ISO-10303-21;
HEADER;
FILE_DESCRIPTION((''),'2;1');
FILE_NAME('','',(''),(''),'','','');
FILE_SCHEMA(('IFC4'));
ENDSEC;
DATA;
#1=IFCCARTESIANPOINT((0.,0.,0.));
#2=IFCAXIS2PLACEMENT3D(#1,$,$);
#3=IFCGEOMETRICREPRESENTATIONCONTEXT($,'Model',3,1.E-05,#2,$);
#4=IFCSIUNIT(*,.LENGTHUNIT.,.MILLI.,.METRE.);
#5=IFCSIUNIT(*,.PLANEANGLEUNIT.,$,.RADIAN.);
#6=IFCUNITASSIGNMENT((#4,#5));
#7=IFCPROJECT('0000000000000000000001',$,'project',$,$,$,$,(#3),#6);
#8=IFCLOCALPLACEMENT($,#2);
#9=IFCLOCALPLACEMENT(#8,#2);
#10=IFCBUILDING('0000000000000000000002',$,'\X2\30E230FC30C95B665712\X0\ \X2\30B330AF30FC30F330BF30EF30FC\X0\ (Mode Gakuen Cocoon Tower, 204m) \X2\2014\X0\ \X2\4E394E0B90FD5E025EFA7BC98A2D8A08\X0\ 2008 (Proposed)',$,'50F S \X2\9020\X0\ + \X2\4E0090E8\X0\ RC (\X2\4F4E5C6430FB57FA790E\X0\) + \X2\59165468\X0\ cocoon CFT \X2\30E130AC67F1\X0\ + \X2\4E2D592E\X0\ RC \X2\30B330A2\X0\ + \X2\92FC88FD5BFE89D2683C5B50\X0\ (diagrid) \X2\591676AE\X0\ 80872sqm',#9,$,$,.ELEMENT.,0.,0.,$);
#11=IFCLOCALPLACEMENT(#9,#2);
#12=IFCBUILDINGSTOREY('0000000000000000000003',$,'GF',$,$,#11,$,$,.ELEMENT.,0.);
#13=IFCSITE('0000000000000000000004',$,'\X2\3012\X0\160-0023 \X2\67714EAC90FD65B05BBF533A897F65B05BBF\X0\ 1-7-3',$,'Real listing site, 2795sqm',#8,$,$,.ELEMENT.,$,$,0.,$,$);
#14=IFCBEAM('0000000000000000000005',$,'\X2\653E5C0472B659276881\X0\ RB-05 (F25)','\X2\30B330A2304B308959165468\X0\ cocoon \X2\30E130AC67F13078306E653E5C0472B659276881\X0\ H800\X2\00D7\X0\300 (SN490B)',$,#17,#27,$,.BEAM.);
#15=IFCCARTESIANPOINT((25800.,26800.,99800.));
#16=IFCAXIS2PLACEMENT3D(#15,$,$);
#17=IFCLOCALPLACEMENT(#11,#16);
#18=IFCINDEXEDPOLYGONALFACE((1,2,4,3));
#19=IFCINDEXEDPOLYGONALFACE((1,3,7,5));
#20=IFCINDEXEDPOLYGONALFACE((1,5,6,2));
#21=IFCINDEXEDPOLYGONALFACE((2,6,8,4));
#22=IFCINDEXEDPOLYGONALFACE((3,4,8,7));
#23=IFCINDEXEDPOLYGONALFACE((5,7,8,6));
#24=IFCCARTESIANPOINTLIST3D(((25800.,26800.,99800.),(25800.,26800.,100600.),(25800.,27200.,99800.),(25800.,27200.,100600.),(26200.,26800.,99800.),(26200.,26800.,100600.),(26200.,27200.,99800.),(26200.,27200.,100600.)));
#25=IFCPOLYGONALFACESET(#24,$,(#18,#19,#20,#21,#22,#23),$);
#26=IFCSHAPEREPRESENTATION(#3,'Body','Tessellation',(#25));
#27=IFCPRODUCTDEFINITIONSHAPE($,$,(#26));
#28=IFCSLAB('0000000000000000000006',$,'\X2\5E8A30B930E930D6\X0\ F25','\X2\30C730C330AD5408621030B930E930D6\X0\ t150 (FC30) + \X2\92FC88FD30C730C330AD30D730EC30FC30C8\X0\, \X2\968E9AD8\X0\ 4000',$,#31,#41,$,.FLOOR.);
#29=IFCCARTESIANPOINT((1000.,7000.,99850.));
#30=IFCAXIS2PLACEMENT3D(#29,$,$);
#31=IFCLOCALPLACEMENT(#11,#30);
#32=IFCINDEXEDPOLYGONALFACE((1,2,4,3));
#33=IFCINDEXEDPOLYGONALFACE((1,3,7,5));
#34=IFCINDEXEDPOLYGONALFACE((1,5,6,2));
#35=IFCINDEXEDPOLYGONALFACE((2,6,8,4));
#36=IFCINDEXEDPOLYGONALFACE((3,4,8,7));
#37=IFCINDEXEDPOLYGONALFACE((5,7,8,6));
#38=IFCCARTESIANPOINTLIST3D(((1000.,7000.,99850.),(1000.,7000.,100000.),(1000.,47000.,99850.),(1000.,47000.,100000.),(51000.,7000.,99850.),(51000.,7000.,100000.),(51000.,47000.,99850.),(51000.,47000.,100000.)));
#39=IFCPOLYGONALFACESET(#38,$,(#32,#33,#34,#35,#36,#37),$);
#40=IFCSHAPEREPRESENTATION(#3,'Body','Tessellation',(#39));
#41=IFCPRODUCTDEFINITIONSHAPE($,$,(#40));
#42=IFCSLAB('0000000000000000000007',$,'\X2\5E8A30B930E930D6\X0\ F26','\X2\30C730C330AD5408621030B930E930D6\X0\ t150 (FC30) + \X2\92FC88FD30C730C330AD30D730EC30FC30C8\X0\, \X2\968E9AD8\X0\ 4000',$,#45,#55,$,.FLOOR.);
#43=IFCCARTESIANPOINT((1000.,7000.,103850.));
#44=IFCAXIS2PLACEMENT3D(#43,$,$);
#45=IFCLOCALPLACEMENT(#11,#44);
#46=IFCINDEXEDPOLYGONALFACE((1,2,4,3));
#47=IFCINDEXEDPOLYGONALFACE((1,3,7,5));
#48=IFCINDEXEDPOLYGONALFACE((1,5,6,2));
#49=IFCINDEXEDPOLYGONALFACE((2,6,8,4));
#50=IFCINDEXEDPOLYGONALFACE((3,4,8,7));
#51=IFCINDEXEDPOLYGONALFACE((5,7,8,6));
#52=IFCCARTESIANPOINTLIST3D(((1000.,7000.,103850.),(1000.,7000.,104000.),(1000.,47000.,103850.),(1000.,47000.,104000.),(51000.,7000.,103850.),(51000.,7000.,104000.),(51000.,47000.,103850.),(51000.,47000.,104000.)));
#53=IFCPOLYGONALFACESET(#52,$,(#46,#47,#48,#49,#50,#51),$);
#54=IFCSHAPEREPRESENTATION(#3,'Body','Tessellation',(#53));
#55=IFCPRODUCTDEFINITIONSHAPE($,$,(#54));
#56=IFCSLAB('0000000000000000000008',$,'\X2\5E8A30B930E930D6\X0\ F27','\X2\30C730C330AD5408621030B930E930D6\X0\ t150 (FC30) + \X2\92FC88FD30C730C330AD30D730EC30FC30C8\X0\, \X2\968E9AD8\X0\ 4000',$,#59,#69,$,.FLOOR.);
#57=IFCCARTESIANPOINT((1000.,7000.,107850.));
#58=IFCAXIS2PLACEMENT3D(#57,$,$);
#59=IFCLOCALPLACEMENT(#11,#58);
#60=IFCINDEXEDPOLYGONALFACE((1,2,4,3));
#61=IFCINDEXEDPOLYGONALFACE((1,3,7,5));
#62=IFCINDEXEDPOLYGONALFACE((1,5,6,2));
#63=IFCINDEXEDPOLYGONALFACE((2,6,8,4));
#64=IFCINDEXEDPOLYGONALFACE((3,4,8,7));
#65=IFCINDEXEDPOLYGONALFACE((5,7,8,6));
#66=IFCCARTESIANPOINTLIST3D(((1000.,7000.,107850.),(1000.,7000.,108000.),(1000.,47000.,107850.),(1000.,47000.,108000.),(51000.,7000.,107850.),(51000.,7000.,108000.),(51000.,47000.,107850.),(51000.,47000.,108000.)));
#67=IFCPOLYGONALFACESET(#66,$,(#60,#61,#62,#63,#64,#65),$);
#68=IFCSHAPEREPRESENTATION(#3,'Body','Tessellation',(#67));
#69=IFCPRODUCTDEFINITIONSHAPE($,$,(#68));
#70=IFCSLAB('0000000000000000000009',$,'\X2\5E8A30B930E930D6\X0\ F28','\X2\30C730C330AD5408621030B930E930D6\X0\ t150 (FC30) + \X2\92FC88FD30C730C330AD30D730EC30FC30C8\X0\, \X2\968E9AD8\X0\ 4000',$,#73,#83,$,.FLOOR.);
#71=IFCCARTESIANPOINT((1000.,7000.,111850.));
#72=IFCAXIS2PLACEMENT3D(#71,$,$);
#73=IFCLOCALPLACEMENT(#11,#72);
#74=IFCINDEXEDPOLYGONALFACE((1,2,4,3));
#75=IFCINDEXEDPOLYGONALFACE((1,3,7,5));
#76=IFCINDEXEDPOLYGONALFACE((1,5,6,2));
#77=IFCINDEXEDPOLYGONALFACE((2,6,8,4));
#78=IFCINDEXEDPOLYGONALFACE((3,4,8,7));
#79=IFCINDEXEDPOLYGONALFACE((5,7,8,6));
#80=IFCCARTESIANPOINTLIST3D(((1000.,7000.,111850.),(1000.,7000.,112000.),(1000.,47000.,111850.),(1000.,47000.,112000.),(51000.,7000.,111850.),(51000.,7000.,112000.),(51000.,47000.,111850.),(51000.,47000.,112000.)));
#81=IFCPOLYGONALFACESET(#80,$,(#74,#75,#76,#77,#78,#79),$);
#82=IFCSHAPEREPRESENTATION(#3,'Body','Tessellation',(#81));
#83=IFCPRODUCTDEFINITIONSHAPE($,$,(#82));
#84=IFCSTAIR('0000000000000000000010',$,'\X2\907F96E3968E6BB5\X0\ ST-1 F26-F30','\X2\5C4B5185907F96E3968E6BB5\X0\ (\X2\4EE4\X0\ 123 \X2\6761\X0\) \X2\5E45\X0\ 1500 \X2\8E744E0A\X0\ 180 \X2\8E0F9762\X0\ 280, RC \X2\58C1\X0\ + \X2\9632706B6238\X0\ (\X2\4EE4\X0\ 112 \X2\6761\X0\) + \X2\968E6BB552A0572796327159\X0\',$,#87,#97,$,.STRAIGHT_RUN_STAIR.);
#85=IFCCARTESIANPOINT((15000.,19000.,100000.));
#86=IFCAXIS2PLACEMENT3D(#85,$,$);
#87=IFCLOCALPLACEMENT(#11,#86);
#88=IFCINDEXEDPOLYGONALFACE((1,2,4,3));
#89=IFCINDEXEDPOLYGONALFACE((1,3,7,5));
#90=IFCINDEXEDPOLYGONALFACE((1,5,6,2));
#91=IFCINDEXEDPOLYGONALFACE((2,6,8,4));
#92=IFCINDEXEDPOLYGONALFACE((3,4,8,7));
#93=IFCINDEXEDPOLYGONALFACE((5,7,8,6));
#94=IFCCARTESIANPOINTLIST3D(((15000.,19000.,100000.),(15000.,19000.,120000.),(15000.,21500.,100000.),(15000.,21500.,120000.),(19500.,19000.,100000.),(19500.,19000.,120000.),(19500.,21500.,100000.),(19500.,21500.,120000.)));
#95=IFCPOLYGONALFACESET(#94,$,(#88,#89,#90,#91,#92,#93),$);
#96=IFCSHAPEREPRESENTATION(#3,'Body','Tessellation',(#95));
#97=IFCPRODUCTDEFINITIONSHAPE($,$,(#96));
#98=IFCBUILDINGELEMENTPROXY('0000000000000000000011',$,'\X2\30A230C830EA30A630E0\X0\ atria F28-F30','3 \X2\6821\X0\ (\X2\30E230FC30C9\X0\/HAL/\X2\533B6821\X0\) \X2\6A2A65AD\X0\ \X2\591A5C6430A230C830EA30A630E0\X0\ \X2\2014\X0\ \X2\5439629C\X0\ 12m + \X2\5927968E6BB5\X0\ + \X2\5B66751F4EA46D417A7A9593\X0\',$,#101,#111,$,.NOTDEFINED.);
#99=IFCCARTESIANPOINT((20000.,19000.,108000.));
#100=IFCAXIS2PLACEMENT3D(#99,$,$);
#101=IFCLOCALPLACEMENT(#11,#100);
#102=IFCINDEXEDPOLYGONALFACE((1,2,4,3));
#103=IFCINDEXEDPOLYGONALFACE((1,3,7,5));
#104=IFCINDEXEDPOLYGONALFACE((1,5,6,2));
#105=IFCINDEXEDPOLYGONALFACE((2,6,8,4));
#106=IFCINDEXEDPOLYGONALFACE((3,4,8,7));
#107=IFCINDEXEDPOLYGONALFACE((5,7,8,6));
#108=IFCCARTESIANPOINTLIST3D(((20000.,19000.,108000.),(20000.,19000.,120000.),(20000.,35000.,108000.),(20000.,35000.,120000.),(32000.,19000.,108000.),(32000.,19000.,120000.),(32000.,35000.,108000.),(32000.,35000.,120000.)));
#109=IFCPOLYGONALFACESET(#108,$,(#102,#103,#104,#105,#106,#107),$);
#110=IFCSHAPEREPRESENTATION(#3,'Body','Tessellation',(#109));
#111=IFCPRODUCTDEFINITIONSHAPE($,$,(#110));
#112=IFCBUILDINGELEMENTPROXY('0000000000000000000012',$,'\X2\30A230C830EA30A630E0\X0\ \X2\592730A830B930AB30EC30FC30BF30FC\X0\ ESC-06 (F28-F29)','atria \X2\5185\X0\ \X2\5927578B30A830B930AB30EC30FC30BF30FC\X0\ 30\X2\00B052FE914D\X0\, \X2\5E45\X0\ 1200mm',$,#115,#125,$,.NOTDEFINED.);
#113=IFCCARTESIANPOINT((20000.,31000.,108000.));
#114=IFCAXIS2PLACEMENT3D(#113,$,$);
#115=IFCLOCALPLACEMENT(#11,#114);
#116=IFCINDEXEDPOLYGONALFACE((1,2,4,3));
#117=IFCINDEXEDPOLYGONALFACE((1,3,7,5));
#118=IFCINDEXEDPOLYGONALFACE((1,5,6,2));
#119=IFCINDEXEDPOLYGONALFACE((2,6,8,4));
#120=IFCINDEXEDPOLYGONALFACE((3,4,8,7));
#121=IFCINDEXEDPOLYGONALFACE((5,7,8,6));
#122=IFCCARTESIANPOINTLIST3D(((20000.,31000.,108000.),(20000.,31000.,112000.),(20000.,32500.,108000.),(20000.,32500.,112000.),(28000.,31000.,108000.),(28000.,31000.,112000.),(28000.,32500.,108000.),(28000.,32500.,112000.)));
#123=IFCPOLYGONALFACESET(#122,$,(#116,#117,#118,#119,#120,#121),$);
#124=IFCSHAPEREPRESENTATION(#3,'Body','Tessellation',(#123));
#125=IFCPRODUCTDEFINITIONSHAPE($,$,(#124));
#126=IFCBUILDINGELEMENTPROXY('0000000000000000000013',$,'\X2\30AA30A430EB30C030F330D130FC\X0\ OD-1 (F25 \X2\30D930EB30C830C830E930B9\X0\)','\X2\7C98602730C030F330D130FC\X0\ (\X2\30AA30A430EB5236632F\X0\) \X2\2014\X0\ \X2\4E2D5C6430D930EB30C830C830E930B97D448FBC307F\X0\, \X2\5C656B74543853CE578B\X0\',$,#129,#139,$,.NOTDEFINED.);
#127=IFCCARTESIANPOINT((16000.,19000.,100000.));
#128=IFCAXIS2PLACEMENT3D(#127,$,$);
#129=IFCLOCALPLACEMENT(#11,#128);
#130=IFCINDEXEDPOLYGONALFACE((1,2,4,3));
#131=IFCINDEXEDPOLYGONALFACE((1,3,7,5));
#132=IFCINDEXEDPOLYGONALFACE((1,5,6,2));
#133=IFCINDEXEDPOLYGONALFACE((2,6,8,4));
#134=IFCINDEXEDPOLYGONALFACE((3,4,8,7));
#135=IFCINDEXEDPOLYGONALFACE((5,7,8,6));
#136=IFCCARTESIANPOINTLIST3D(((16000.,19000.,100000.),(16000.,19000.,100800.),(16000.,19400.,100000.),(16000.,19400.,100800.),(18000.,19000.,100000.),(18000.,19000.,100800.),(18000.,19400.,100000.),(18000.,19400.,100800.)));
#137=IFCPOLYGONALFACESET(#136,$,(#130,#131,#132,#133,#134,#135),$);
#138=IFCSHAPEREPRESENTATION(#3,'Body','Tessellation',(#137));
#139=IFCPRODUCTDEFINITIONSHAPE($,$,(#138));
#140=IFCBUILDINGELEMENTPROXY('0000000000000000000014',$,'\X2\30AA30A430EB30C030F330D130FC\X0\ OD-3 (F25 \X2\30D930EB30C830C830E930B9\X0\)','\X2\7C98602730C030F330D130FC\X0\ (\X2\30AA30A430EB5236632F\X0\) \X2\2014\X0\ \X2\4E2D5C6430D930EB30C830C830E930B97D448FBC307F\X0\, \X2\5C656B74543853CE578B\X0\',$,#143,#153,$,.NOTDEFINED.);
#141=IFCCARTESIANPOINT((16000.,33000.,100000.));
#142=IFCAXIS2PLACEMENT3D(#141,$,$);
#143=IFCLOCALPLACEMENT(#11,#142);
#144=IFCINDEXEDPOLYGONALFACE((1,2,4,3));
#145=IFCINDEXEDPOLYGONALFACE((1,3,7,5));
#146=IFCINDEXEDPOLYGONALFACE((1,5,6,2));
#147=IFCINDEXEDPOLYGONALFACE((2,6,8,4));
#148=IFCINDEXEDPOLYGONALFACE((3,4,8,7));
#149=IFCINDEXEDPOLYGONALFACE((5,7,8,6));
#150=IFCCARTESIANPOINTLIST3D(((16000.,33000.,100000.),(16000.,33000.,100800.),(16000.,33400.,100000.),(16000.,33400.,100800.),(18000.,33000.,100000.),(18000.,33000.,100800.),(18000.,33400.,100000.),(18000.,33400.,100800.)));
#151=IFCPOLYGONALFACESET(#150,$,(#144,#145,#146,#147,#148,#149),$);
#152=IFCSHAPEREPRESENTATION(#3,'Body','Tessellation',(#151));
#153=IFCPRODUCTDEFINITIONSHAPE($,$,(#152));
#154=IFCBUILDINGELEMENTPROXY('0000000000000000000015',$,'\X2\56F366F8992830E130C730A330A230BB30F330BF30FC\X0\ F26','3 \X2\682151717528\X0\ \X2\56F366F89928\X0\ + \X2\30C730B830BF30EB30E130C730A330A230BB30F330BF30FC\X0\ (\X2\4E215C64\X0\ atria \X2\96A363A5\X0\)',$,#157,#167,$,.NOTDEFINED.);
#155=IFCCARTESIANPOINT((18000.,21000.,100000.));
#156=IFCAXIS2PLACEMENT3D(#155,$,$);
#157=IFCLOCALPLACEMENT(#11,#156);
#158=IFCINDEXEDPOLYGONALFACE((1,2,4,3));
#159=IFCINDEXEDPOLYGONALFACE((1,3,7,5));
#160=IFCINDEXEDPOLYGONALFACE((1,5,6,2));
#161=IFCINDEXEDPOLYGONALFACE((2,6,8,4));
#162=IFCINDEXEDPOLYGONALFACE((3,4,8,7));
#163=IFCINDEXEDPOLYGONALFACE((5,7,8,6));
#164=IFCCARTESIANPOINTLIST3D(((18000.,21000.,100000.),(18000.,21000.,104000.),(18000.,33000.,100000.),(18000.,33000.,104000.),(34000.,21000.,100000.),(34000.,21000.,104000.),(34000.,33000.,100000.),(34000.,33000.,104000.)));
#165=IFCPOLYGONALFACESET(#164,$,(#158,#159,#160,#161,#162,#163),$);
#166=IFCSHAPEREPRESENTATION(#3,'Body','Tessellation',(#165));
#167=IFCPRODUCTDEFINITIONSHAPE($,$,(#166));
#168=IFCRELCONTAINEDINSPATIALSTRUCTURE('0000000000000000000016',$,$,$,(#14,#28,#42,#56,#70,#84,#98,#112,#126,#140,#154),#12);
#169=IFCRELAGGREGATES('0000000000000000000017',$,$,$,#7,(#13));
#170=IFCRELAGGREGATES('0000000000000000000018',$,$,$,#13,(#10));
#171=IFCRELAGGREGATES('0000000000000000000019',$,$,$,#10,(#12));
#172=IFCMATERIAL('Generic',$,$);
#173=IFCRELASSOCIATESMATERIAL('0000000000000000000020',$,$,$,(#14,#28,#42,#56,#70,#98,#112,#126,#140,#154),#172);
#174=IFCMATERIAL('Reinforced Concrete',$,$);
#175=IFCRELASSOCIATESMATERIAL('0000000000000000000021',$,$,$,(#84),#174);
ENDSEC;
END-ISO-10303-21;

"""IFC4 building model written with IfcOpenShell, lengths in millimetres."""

from ifc_helpers import new_model, si_unit, frame, frame_2d, origin, place, context, project, spatial, rectangle, extrude, material, element, save


model = new_model("IFC4")

# Units and contexts
model_context = context("Model", 3, precision=1e-05, world=origin())
ifc_project = project(units=[si_unit("LENGTHUNIT", "METRE", prefix="MILLI"), si_unit("PLANEANGLEUNIT", "RADIAN")], contexts=[model_context])

# Site, building, storey
site_placement = place(None, origin())
site = spatial("IfcSite", under=ifc_project, at=site_placement, Name="〒160-0023 東京都新宿区西新宿 1-7-3", ObjectType="Real listing site, 2795sqm", CompositionType="ELEMENT", RefElevation=0.0)
building_placement = place(site_placement, origin())
building = spatial("IfcBuilding", under=site, at=building_placement, Name="モード学園 コクーンタワー (Mode Gakuen Cocoon Tower, 204m) — 丹下都市建築設計 2008 (Proposed)", ObjectType="50F S 造 + 一部 RC (低層・基礎) + 外周 cocoon CFT メガ柱 + 中央 RC コア + 鋼製対角格子 (diagrid) 外皮 80872sqm", CompositionType="ELEMENT", ElevationOfRefHeight=0.0, ElevationOfTerrain=0.0)
storey_placement = place(building_placement, origin())
storey = spatial("IfcBuildingStorey", under=building, at=storey_placement, Name="GF", CompositionType="ELEMENT", Elevation=0.0)

# Shared definitions
ifc_material_1 = material(Name="Generic")

# Beam
beam_1_placement = place(storey_placement, frame((25800.0, 26800.0, 99800.0)))
element("IfcBeam", 1, at=beam_1_placement, inside=storey, material=ifc_material_1, Name="放射状大梁 RB-05 (F25)", Description="コアから外周 cocoon メガ柱への放射状大梁 H800×300 (SN490B)", PredefinedType="BEAM", context=model_context, shape_type="SweptSolid", body=[
    extrude(rectangle(XDim=400.0, YDim=400.0, at=frame_2d((200.0, 200.0))), frame((25800.0, 26800.0, 99800.0)), (0.0, 0.0, 1.0), 800.0),
])

# Slabs
slab_1_placement = place(storey_placement, frame((1000.0, 7000.0, 99850.0)))
element("IfcSlab", 2, at=slab_1_placement, inside=storey, material=ifc_material_1, Name="床スラブ F25", Description="デッキ合成スラブ t150 (FC30) + 鋼製デッキプレート, 階高 4000", PredefinedType="FLOOR", context=model_context, shape_type="SweptSolid", body=[
    extrude(rectangle(XDim=50000.0, YDim=40000.0, at=frame_2d((25000.0, 20000.0))), frame((1000.0, 7000.0, 99850.0)), (0.0, 0.0, 1.0), 150.0),
])
slab_2_placement = place(storey_placement, frame((1000.0, 7000.0, 103850.0)))
element("IfcSlab", 3, at=slab_2_placement, inside=storey, material=ifc_material_1, Name="床スラブ F26", Description="デッキ合成スラブ t150 (FC30) + 鋼製デッキプレート, 階高 4000", PredefinedType="FLOOR", context=model_context, shape_type="SweptSolid", body=[
    extrude(rectangle(XDim=50000.0, YDim=40000.0, at=frame_2d((25000.0, 20000.0))), frame((1000.0, 7000.0, 103850.0)), (0.0, 0.0, 1.0), 150.0),
])
slab_3_placement = place(storey_placement, frame((1000.0, 7000.0, 107850.0)))
element("IfcSlab", 4, at=slab_3_placement, inside=storey, material=ifc_material_1, Name="床スラブ F27", Description="デッキ合成スラブ t150 (FC30) + 鋼製デッキプレート, 階高 4000", PredefinedType="FLOOR", context=model_context, shape_type="SweptSolid", body=[
    extrude(rectangle(XDim=50000.0, YDim=40000.0, at=frame_2d((25000.0, 20000.0))), frame((1000.0, 7000.0, 107850.0)), (0.0, 0.0, 1.0), 150.0),
])
slab_4_placement = place(storey_placement, frame((1000.0, 7000.0, 111850.0)))
element("IfcSlab", 5, at=slab_4_placement, inside=storey, material=ifc_material_1, Name="床スラブ F28", Description="デッキ合成スラブ t150 (FC30) + 鋼製デッキプレート, 階高 4000", PredefinedType="FLOOR", context=model_context, shape_type="SweptSolid", body=[
    extrude(rectangle(XDim=50000.0, YDim=40000.0, at=frame_2d((25000.0, 20000.0))), frame((1000.0, 7000.0, 111850.0)), (0.0, 0.0, 1.0), 150.0),
])

# Stair
ifc_material_2 = material(Name="Reinforced Concrete")
stair_placement = place(storey_placement, frame((15000.0, 19000.0, 100000.0)))
element("IfcStair", 6, at=stair_placement, inside=storey, material=ifc_material_2, Name="避難階段 ST-1 F26-F30", Description="屋内避難階段 (令 123 条) 幅 1500 蹴上 180 踏面 280, RC 壁 + 防火戸 (令 112 条) + 階段加圧防煙", PredefinedType="STRAIGHT_RUN_STAIR", context=model_context, shape_type="SweptSolid", body=[
    extrude(rectangle(XDim=4500.0, YDim=2500.0, at=frame_2d((2250.0, 1250.0))), frame((15000.0, 19000.0, 100000.0)), (0.0, 0.0, 1.0), 20000.0),
])

# Building element proxies
proxy_1_placement = place(storey_placement, frame((20000.0, 19000.0, 108000.0)))
element("IfcBuildingElementProxy", 7, at=proxy_1_placement, inside=storey, material=ifc_material_1, Name="アトリウム atria F28-F30", Description="3 校 (モード/HAL/医校) 横断 多層アトリウム — 吹抜 12m + 大階段 + 学生交流空間", PredefinedType="NOTDEFINED", context=model_context, shape_type="SweptSolid", body=[
    extrude(rectangle(XDim=12000.0, YDim=16000.0, at=frame_2d((6000.0, 8000.0))), frame((20000.0, 19000.0, 108000.0)), (0.0, 0.0, 1.0), 12000.0),
])
proxy_2_placement = place(storey_placement, frame((20000.0, 31000.0, 108000.0)))
element("IfcBuildingElementProxy", 8, at=proxy_2_placement, inside=storey, material=ifc_material_1, Name="アトリウム 大エスカレーター ESC-06 (F28-F29)", Description="atria 内 大型エスカレーター 30°勾配, 幅 1200mm", PredefinedType="NOTDEFINED", context=model_context, shape_type="SweptSolid", body=[
    extrude(rectangle(XDim=8000.0, YDim=1500.0, at=frame_2d((4000.0, 750.0))), frame((20000.0, 31000.0, 108000.0)), (0.0, 0.0, 1.0), 4000.0),
])
proxy_3_placement = place(storey_placement, frame((16000.0, 19000.0, 100000.0)))
element("IfcBuildingElementProxy", 9, at=proxy_3_placement, inside=storey, material=ifc_material_1, Name="オイルダンパー OD-1 (F25 ベルトトラス)", Description="粘性ダンパー (オイル制振) — 中層ベルトトラス組込み, 履歴吸収型", PredefinedType="NOTDEFINED", context=model_context, shape_type="SweptSolid", body=[
    extrude(rectangle(XDim=2000.0, YDim=400.0, at=frame_2d((1000.0, 200.0))), frame((16000.0, 19000.0, 100000.0)), (0.0, 0.0, 1.0), 800.0),
])
proxy_4_placement = place(storey_placement, frame((16000.0, 33000.0, 100000.0)))
element("IfcBuildingElementProxy", 10, at=proxy_4_placement, inside=storey, material=ifc_material_1, Name="オイルダンパー OD-3 (F25 ベルトトラス)", Description="粘性ダンパー (オイル制振) — 中層ベルトトラス組込み, 履歴吸収型", PredefinedType="NOTDEFINED", context=model_context, shape_type="SweptSolid", body=[
    extrude(rectangle(XDim=2000.0, YDim=400.0, at=frame_2d((1000.0, 200.0))), frame((16000.0, 33000.0, 100000.0)), (0.0, 0.0, 1.0), 800.0),
])
proxy_5_placement = place(storey_placement, frame((18000.0, 21000.0, 100000.0)))
element("IfcBuildingElementProxy", 11, at=proxy_5_placement, inside=storey, material=ifc_material_1, Name="図書館メディアセンター F26", Description="3 校共用 図書館 + デジタルメディアセンター (両層 atria 隣接)", PredefinedType="NOTDEFINED", context=model_context, shape_type="SweptSolid", body=[
    extrude(rectangle(XDim=16000.0, YDim=12000.0, at=frame_2d((8000.0, 6000.0))), frame((18000.0, 21000.0, 100000.0)), (0.0, 0.0, 1.0), 4000.0),
])

save(model, "model.ifc")
